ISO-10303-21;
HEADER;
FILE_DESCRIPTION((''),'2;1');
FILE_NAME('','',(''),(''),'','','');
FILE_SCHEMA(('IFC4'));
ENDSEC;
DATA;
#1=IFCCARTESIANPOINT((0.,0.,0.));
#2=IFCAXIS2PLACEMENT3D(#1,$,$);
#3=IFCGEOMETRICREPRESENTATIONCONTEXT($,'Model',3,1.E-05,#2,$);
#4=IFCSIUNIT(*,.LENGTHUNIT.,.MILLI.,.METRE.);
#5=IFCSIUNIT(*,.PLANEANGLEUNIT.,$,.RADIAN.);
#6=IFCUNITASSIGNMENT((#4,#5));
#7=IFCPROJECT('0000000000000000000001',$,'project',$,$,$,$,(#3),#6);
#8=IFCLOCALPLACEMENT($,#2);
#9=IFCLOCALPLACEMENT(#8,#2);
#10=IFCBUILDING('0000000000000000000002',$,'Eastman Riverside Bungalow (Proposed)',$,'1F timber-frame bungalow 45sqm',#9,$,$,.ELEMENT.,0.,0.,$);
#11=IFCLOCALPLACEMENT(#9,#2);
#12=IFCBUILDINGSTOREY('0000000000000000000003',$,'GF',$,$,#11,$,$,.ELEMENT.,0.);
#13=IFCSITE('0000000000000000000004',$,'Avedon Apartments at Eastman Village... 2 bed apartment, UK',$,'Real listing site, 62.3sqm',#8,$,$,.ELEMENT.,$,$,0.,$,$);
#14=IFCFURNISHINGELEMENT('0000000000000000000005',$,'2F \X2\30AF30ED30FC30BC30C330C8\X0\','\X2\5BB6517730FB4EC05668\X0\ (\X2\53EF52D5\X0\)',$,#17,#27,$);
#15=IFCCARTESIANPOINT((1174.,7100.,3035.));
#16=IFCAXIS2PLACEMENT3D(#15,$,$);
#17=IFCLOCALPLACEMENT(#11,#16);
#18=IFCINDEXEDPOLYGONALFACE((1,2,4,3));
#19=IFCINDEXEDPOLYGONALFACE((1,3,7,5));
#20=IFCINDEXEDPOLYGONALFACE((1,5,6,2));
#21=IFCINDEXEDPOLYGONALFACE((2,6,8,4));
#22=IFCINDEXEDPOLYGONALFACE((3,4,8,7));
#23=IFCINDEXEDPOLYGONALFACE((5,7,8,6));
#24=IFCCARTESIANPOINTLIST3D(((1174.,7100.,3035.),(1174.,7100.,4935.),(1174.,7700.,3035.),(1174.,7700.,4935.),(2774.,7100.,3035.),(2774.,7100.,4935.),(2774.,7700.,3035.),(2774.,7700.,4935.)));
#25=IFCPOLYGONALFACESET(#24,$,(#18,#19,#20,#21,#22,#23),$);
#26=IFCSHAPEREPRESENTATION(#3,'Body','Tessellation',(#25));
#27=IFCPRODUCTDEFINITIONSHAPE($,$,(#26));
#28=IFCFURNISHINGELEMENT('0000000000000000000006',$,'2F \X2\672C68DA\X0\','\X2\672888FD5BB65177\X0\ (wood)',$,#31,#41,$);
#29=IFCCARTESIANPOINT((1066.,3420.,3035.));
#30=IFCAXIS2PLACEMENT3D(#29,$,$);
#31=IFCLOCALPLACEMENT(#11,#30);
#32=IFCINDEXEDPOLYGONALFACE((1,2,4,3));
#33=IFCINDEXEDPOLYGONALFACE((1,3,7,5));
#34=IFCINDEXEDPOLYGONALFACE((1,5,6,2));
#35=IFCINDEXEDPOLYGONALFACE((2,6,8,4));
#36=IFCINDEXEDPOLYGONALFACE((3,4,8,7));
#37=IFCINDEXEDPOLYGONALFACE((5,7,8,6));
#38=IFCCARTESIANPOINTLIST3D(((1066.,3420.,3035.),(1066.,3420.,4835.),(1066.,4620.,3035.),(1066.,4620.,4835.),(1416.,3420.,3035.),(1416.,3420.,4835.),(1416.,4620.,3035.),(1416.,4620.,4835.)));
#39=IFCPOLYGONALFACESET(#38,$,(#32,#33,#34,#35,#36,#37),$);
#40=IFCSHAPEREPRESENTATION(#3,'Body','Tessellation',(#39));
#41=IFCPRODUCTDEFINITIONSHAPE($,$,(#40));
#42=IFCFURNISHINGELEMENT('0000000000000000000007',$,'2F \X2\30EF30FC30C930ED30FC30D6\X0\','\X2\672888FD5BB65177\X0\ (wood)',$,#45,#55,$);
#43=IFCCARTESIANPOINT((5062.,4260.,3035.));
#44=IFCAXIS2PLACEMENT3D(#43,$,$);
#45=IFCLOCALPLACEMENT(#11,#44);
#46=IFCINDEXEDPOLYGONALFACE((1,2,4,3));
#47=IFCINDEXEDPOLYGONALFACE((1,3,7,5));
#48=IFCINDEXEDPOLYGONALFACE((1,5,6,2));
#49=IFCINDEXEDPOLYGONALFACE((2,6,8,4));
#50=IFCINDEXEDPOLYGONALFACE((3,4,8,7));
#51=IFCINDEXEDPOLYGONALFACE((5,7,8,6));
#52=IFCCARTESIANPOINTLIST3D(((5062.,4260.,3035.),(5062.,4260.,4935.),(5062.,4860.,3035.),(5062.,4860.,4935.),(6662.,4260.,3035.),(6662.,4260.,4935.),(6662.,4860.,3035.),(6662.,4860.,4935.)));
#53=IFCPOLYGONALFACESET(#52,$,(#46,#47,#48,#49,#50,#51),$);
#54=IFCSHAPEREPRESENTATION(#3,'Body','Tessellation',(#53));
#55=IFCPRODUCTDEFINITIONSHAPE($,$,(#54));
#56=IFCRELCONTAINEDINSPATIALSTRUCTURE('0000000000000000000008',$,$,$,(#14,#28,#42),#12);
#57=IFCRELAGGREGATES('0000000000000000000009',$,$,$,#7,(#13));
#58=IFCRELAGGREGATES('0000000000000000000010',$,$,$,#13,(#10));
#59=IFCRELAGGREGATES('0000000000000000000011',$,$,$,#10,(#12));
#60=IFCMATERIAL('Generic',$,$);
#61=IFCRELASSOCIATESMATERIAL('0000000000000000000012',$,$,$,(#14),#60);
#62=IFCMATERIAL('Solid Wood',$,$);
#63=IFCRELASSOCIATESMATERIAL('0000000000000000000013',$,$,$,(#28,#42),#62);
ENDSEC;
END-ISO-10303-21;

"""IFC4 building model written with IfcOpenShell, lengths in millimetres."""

from ifc_helpers import new_model, si_unit, frame, frame_2d, origin, place, context, project, spatial, rectangle, extrude, material, element, save


model = new_model("IFC4")

# Units and contexts
model_context = context("Model", 3, precision=1e-05, world=origin())
ifc_project = project(units=[si_unit("LENGTHUNIT", "METRE", prefix="MILLI"), si_unit("PLANEANGLEUNIT", "RADIAN")], contexts=[model_context])

# Site, building, storey
site_placement = place(None, origin())
site = spatial("IfcSite", under=ifc_project, at=site_placement, Name="Avedon Apartments at Eastman Village... 2 bed apartment, UK", ObjectType="Real listing site, 62.3sqm", CompositionType="ELEMENT", RefElevation=0.0)
building_placement = place(site_placement, origin())
building = spatial("IfcBuilding", under=site, at=building_placement, Name="Eastman Riverside Bungalow (Proposed)", ObjectType="1F timber-frame bungalow 45sqm", CompositionType="ELEMENT", ElevationOfRefHeight=0.0, ElevationOfTerrain=0.0)
storey_placement = place(building_placement, origin())
storey = spatial("IfcBuildingStorey", under=building, at=storey_placement, Name="GF", CompositionType="ELEMENT", Elevation=0.0)

# Shared definitions
ifc_material_1 = material(Name="Solid Wood")

# Shared definitions
ifc_material_2 = material(Name="Generic")

# Furnishing elements
furnishing_1_placement = place(storey_placement, frame((1174.0, 7100.0, 3035.0)))
element("IfcFurnishingElement", 1, at=furnishing_1_placement, inside=storey, material=ifc_material_2, Name="2F クローゼット", Description="家具・什器 (可動)", context=model_context, shape_type="SweptSolid", body=[
    extrude(rectangle(XDim=1600.0, YDim=600.0, at=frame_2d((800.0, 300.0))), frame((1174.0, 7100.0, 3035.0)), (0.0, 0.0, 1.0), 1900.0),
])
furnishing_2_placement = place(storey_placement, frame((1066.0, 3420.0, 3035.0)))
element("IfcFurnishingElement", 2, at=furnishing_2_placement, inside=storey, material=ifc_material_1, Name="2F 本棚", Description="木製家具 (wood)", context=model_context, shape_type="SweptSolid", body=[
    extrude(rectangle(XDim=350.0, YDim=1200.0, at=frame_2d((175.0, 600.0))), frame((1066.0, 3420.0, 3035.0)), (0.0, 0.0, 1.0), 1800.0),
])
furnishing_3_placement = place(storey_placement, frame((5062.0, 4260.0, 3035.0)))
element("IfcFurnishingElement", 3, at=furnishing_3_placement, inside=storey, material=ifc_material_1, Name="2F ワードローブ", Description="木製家具 (wood)", context=model_context, shape_type="SweptSolid", body=[
    extrude(rectangle(XDim=1600.0, YDim=600.0, at=frame_2d((800.0, 300.0))), frame((5062.0, 4260.0, 3035.0)), (0.0, 0.0, 1.0), 1900.0),
])

save(model, "model.ifc")
